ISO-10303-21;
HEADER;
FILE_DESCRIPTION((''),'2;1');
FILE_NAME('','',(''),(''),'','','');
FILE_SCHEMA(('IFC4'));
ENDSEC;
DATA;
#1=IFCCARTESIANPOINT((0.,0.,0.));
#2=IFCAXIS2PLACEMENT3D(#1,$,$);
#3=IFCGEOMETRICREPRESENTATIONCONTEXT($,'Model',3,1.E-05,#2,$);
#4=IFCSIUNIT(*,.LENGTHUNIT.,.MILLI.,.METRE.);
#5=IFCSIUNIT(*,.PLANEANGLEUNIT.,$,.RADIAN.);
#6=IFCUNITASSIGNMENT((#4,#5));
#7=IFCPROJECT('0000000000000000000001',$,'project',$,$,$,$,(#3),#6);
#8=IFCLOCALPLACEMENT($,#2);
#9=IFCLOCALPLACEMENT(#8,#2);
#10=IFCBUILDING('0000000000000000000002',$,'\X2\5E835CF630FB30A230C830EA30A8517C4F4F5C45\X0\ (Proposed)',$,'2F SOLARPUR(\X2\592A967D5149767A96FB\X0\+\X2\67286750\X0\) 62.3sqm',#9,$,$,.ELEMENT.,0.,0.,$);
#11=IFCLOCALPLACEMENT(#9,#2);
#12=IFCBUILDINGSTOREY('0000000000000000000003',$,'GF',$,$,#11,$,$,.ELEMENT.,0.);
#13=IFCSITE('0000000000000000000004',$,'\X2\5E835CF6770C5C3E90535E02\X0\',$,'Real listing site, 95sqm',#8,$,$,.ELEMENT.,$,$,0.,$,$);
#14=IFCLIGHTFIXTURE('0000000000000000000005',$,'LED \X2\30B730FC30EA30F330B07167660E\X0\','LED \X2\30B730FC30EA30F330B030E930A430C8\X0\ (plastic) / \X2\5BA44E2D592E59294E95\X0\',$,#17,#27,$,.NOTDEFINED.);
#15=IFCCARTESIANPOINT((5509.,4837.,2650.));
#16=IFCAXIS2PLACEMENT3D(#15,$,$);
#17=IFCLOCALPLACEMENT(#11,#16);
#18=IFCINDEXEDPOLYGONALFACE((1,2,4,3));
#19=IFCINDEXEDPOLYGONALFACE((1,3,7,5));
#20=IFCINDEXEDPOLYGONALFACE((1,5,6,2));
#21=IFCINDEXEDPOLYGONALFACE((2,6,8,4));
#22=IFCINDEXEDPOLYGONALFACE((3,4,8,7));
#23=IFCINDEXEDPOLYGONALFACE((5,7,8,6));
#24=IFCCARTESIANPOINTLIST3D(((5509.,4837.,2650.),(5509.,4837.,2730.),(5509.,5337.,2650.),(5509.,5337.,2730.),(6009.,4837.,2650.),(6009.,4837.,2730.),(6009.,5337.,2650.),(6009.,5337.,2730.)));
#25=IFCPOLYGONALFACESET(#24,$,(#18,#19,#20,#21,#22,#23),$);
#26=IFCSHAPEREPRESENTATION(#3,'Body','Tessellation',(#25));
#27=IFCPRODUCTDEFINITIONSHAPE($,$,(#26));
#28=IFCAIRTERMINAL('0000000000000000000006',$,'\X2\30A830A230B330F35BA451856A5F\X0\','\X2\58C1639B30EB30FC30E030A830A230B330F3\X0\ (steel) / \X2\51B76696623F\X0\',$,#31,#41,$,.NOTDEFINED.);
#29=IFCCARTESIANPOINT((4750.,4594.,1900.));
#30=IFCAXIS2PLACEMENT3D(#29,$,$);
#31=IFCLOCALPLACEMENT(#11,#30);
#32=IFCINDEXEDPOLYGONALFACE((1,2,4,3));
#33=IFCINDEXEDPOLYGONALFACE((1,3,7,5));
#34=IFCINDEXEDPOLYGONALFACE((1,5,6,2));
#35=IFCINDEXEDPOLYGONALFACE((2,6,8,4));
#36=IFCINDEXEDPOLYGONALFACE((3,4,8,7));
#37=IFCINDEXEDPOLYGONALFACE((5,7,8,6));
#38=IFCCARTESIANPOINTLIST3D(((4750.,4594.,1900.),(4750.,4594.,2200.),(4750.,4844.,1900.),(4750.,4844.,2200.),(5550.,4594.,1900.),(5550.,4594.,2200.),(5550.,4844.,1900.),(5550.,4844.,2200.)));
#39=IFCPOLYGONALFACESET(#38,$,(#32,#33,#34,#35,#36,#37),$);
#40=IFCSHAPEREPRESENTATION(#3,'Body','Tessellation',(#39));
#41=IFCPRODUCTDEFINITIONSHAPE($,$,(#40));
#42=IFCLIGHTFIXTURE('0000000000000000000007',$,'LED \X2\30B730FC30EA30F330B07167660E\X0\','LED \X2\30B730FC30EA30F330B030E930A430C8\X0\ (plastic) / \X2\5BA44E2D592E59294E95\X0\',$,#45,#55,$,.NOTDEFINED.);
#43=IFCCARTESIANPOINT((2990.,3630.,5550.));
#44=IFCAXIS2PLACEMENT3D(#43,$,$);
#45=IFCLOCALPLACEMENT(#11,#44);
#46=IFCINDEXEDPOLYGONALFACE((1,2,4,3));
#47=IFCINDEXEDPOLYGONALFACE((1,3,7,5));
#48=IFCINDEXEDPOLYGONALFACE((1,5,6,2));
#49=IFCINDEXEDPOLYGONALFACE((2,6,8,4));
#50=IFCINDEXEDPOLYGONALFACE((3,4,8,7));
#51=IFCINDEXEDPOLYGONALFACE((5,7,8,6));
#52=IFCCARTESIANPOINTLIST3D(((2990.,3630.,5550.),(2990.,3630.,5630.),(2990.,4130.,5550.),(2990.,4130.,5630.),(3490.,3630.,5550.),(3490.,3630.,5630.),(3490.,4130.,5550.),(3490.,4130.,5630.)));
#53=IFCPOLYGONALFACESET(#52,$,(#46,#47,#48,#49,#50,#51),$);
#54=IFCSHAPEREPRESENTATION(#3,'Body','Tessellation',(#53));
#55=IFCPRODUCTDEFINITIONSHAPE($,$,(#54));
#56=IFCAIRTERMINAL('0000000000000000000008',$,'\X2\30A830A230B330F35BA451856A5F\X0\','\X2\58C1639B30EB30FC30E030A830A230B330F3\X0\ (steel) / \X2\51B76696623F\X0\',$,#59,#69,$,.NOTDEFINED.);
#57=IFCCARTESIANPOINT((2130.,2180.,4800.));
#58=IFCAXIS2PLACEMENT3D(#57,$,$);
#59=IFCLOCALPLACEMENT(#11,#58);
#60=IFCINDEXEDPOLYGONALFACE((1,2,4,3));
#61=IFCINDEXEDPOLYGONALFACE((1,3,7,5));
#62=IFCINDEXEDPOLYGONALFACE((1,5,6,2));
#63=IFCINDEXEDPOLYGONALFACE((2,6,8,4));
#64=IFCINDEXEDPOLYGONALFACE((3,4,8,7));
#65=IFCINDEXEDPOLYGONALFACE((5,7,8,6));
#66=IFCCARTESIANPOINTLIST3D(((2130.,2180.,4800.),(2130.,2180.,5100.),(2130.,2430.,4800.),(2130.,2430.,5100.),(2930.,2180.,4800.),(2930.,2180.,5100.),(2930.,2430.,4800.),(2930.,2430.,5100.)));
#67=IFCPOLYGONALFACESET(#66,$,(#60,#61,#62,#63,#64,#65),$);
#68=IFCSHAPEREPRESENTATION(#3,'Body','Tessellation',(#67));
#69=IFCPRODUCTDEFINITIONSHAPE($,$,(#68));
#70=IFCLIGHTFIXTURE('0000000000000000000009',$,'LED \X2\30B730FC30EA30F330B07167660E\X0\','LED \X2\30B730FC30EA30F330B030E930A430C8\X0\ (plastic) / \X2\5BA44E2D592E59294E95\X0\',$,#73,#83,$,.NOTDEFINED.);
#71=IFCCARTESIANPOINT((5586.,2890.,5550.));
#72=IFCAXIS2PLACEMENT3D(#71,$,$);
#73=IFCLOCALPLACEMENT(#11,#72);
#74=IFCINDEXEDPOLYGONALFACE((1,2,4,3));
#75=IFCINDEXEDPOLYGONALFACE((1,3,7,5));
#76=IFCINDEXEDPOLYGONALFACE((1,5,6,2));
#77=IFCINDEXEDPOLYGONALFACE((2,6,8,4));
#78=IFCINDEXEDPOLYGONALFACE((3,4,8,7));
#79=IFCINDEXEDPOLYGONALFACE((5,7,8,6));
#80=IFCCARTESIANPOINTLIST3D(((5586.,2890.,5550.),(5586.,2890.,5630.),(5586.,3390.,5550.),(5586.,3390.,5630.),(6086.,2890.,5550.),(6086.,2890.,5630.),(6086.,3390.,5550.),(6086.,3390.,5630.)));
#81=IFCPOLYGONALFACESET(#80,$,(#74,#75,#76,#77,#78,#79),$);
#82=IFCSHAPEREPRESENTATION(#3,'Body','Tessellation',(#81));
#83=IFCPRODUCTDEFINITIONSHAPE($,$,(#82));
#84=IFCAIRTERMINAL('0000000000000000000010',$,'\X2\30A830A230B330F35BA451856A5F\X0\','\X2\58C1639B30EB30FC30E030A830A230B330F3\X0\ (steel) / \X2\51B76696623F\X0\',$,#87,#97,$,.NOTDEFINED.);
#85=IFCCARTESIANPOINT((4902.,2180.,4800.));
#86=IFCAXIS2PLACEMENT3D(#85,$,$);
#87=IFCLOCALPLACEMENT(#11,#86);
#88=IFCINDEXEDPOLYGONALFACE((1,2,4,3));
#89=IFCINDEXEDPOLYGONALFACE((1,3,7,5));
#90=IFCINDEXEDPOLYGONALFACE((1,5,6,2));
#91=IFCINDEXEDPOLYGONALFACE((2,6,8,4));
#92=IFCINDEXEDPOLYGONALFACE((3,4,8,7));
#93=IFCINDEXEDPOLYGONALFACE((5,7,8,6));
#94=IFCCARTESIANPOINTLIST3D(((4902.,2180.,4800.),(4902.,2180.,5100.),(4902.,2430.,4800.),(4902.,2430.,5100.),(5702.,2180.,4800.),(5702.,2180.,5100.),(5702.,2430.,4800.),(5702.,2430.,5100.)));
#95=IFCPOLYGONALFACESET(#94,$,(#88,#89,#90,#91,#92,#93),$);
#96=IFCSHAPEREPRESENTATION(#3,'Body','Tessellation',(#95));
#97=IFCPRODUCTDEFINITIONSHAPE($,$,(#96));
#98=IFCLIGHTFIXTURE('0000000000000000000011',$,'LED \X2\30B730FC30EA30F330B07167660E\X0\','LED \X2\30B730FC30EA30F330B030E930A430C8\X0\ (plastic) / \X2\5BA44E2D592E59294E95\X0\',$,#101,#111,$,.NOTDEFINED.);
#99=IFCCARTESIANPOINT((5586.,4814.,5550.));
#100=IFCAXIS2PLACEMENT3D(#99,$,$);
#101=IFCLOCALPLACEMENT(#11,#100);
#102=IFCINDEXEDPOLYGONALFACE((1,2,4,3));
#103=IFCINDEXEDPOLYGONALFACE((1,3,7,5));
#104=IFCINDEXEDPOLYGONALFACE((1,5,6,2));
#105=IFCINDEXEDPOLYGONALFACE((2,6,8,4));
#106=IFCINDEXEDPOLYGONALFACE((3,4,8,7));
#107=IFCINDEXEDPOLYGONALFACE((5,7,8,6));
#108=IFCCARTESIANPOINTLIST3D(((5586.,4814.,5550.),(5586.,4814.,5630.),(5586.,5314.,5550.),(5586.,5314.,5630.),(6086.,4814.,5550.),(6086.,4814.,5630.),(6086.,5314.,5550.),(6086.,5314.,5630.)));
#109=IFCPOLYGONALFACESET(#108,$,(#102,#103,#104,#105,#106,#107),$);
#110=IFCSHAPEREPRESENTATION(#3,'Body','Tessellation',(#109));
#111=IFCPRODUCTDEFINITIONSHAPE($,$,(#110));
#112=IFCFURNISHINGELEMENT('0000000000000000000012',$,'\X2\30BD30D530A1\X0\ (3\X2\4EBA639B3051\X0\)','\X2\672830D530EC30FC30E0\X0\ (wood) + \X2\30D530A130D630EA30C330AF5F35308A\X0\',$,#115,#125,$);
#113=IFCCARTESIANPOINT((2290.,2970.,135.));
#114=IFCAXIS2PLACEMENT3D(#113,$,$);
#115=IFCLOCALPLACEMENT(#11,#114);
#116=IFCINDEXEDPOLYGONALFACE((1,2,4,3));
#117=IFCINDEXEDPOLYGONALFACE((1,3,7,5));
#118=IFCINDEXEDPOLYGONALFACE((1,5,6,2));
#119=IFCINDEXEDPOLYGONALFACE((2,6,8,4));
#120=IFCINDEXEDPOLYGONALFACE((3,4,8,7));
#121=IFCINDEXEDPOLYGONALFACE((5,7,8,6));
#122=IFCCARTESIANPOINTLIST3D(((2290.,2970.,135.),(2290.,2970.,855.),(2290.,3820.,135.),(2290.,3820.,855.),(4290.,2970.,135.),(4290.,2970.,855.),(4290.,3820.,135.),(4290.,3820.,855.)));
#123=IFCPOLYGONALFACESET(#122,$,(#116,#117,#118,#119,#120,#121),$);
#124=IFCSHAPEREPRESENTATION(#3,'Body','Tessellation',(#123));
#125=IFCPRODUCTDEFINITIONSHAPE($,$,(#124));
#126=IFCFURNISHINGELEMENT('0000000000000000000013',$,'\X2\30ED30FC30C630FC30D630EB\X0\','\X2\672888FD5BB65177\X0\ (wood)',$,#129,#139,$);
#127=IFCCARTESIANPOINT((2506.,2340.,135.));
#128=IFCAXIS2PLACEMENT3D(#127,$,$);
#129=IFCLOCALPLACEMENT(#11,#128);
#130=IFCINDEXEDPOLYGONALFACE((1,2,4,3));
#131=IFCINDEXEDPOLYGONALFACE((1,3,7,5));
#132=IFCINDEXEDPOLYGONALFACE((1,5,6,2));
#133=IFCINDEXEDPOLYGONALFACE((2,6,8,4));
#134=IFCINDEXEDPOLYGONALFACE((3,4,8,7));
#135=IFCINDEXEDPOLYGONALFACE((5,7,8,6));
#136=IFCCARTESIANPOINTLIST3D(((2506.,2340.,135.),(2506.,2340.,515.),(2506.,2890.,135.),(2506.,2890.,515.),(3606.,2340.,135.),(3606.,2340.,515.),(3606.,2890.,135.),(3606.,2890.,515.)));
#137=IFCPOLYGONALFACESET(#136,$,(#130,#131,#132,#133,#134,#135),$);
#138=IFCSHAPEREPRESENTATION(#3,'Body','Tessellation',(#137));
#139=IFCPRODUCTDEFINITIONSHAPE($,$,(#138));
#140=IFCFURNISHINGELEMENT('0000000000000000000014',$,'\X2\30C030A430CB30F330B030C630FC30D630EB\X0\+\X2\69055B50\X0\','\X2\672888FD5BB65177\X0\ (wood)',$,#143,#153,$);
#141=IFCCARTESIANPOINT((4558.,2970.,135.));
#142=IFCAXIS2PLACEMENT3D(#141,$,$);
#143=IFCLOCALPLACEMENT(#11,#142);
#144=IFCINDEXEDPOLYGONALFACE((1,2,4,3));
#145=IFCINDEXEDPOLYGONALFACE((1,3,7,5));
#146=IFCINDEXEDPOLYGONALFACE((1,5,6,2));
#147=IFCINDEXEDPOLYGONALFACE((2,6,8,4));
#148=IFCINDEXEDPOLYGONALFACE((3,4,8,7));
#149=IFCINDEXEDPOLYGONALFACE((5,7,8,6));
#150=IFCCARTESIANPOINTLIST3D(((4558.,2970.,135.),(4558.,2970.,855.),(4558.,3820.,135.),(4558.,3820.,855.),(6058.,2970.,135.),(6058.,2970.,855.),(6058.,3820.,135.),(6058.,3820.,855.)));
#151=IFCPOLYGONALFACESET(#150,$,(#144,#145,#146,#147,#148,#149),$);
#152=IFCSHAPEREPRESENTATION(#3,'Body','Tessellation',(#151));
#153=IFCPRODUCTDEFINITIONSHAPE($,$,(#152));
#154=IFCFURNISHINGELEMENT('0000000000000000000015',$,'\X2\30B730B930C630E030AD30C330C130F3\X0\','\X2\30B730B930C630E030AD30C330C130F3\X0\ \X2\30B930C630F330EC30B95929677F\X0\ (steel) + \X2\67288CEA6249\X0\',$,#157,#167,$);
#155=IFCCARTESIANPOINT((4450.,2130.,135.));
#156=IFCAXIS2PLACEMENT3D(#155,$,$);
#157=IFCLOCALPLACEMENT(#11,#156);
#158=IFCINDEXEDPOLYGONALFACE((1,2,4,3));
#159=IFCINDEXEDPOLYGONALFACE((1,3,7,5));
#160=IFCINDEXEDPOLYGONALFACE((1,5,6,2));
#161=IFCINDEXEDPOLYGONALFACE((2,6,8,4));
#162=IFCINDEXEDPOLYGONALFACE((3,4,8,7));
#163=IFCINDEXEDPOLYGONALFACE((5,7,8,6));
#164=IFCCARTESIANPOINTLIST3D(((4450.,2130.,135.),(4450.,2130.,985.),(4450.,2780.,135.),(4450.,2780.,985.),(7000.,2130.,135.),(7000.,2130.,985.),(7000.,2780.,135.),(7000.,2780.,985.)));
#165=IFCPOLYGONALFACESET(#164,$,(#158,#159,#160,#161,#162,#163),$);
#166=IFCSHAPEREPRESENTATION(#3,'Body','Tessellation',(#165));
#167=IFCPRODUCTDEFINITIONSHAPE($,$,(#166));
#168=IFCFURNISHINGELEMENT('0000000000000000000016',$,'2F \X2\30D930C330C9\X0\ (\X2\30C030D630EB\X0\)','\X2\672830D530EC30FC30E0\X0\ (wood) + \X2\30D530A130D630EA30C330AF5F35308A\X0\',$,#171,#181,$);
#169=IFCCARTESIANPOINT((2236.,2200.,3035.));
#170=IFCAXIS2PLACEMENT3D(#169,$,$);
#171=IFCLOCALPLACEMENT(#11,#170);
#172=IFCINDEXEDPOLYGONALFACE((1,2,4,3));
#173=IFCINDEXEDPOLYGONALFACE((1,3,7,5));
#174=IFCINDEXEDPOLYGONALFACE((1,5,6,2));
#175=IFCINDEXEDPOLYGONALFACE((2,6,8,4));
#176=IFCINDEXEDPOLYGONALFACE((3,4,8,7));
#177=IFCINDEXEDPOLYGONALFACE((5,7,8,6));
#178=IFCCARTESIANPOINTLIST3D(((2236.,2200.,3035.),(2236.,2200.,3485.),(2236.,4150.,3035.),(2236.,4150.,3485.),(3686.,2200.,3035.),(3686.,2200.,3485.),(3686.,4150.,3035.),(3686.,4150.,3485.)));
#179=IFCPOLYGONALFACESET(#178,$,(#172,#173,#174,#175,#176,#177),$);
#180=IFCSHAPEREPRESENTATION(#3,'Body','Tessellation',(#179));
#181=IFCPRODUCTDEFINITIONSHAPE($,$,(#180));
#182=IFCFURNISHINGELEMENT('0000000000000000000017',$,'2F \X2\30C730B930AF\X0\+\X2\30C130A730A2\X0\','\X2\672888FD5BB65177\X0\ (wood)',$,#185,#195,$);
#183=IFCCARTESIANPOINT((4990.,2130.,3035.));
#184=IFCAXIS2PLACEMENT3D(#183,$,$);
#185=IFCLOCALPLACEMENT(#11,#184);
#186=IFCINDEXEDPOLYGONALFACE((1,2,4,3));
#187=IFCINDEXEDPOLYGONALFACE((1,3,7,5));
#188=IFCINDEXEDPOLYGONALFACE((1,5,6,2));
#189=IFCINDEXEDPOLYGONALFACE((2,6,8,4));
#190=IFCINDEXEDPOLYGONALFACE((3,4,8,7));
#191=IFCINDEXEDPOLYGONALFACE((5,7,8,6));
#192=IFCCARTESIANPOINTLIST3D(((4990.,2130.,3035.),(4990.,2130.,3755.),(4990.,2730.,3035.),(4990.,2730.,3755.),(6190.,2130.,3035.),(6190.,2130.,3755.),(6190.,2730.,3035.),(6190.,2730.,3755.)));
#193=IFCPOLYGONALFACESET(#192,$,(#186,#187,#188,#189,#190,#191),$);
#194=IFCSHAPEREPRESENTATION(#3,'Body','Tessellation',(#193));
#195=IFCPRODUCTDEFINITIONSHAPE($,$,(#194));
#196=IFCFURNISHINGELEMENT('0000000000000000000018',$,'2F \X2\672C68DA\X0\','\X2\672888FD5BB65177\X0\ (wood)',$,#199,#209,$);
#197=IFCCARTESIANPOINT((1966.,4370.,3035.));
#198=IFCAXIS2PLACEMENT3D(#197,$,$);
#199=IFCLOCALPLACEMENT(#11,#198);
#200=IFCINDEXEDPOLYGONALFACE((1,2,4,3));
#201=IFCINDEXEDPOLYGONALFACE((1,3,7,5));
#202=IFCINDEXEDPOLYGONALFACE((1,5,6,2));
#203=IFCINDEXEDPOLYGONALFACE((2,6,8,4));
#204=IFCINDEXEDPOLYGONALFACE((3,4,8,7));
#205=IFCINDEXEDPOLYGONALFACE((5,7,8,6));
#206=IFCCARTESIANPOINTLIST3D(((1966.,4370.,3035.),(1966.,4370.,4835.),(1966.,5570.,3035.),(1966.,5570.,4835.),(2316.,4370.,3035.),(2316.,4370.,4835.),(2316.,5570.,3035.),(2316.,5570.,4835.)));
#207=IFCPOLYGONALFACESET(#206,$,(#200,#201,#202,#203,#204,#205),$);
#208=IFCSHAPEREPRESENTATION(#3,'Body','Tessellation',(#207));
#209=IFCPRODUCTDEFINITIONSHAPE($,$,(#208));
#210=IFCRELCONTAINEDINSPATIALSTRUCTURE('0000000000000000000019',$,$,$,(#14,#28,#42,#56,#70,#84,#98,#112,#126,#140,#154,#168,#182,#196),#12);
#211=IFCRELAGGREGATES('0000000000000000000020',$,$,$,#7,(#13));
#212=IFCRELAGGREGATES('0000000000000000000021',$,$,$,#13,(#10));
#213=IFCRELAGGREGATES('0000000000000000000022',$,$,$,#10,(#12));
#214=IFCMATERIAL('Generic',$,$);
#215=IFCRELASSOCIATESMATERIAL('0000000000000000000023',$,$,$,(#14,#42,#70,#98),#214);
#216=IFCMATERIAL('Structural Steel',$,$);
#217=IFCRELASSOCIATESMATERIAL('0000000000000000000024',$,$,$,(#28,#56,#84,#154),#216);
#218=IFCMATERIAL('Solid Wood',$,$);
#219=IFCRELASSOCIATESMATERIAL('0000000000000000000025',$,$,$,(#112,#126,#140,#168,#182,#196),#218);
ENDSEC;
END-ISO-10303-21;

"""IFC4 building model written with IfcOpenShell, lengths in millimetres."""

from ifc_helpers import new_model, si_unit, frame, frame_2d, origin, place, context, project, spatial, rectangle, extrude, material, element, save


model = new_model("IFC4")

# Units and contexts
model_context = context("Model", 3, precision=1e-05, world=origin())
ifc_project = project(units=[si_unit("LENGTHUNIT", "METRE", prefix="MILLI"), si_unit("PLANEANGLEUNIT", "RADIAN")], contexts=[model_context])

# Site, building, storey
site_placement = place(None, origin())
site = spatial("IfcSite", under=ifc_project, at=site_placement, Name="広島県尾道市", ObjectType="Real listing site, 95sqm", CompositionType="ELEMENT", RefElevation=0.0)
building_placement = place(site_placement, origin())
building = spatial("IfcBuilding", under=site, at=building_placement, Name="広島・アトリエ兼住居 (Proposed)", ObjectType="2F SOLARPUR(太陽光発電+木材) 62.3sqm", CompositionType="ELEMENT", ElevationOfRefHeight=0.0, ElevationOfTerrain=0.0)
storey_placement = place(building_placement, origin())
storey = spatial("IfcBuildingStorey", under=building, at=storey_placement, Name="GF", CompositionType="ELEMENT", Elevation=0.0)

# Shared definitions
ifc_material_1 = material(Name="Solid Wood")

# Shared definitions
ifc_material_2 = material(Name="Structural Steel")

# Shared definitions
ifc_material_3 = material(Name="Generic")

# Light fixture
light_fixture_1_placement = place(storey_placement, frame((5509.0, 4837.0, 2650.0)))
element("IfcLightFixture", 1, at=light_fixture_1_placement, inside=storey, material=ifc_material_3, Name="LED シーリング照明", Description="LED シーリングライト (plastic) / 室中央天井", PredefinedType="NOTDEFINED", context=model_context, shape_type="SweptSolid", body=[
    extrude(rectangle(XDim=500.0, YDim=500.0, at=frame_2d((250.0, 250.0))), frame((5509.0, 4837.0, 2650.0)), (0.0, 0.0, 1.0), 80.0),
])

# Air terminal
air_terminal_1_placement = place(storey_placement, frame((4750.0, 4594.0, 1900.0)))
element("IfcAirTerminal", 2, at=air_terminal_1_placement, inside=storey, material=ifc_material_2, Name="エアコン室内機", Description="壁掛ルームエアコン (steel) / 冷暖房", PredefinedType="NOTDEFINED", context=model_context, shape_type="SweptSolid", body=[
    extrude(rectangle(XDim=800.0, YDim=250.0, at=frame_2d((400.0, 125.0))), frame((4750.0, 4594.0, 1900.0)), (0.0, 0.0, 1.0), 300.0),
])

# Light fixture
light_fixture_2_placement = place(storey_placement, frame((2990.0, 3630.0, 5550.0)))
element("IfcLightFixture", 3, at=light_fixture_2_placement, inside=storey, material=ifc_material_3, Name="LED シーリング照明", Description="LED シーリングライト (plastic) / 室中央天井", PredefinedType="NOTDEFINED", context=model_context, shape_type="SweptSolid", body=[
    extrude(rectangle(XDim=500.0, YDim=500.0, at=frame_2d((250.0, 250.0))), frame((2990.0, 3630.0, 5550.0)), (0.0, 0.0, 1.0), 80.0),
])

# Air terminal
air_terminal_2_placement = place(storey_placement, frame((2130.0, 2180.0, 4800.0)))
element("IfcAirTerminal", 4, at=air_terminal_2_placement, inside=storey, material=ifc_material_2, Name="エアコン室内機", Description="壁掛ルームエアコン (steel) / 冷暖房", PredefinedType="NOTDEFINED", context=model_context, shape_type="SweptSolid", body=[
    extrude(rectangle(XDim=800.0, YDim=250.0, at=frame_2d((400.0, 125.0))), frame((2130.0, 2180.0, 4800.0)), (0.0, 0.0, 1.0), 300.0),
])

# Light fixture
light_fixture_3_placement = place(storey_placement, frame((5586.0, 2890.0, 5550.0)))
element("IfcLightFixture", 5, at=light_fixture_3_placement, inside=storey, material=ifc_material_3, Name="LED シーリング照明", Description="LED シーリングライト (plastic) / 室中央天井", PredefinedType="NOTDEFINED", context=model_context, shape_type="SweptSolid", body=[
    extrude(rectangle(XDim=500.0, YDim=500.0, at=frame_2d((250.0, 250.0))), frame((5586.0, 2890.0, 5550.0)), (0.0, 0.0, 1.0), 80.0),
])

# Air terminal
air_terminal_3_placement = place(storey_placement, frame((4902.0, 2180.0, 4800.0)))
element("IfcAirTerminal", 6, at=air_terminal_3_placement, inside=storey, material=ifc_material_2, Name="エアコン室内機", Description="壁掛ルームエアコン (steel) / 冷暖房", PredefinedType="NOTDEFINED", context=model_context, shape_type="SweptSolid", body=[
    extrude(rectangle(XDim=800.0, YDim=250.0, at=frame_2d((400.0, 125.0))), frame((4902.0, 2180.0, 4800.0)), (0.0, 0.0, 1.0), 300.0),
])

# Light fixture
light_fixture_4_placement = place(storey_placement, frame((5586.0, 4814.0, 5550.0)))
element("IfcLightFixture", 7, at=light_fixture_4_placement, inside=storey, material=ifc_material_3, Name="LED シーリング照明", Description="LED シーリングライト (plastic) / 室中央天井", PredefinedType="NOTDEFINED", context=model_context, shape_type="SweptSolid", body=[
    extrude(rectangle(XDim=500.0, YDim=500.0, at=frame_2d((250.0, 250.0))), frame((5586.0, 4814.0, 5550.0)), (0.0, 0.0, 1.0), 80.0),
])

# Furnishing elements
furnishing_1_placement = place(storey_placement, frame((2290.0, 2970.0, 135.0)))
element("IfcFurnishingElement", 8, at=furnishing_1_placement, inside=storey, material=ifc_material_1, Name="ソファ (3人掛け)", Description="木フレーム (wood) + ファブリック張り", context=model_context, shape_type="SweptSolid", body=[
    extrude(rectangle(XDim=2000.0, YDim=850.0, at=frame_2d((1000.0, 425.0))), frame((2290.0, 2970.0, 135.0)), (0.0, 0.0, 1.0), 720.0),
])
furnishing_2_placement = place(storey_placement, frame((2506.0, 2340.0, 135.0)))
element("IfcFurnishingElement", 9, at=furnishing_2_placement, inside=storey, material=ifc_material_1, Name="ローテーブル", Description="木製家具 (wood)", context=model_context, shape_type="SweptSolid", body=[
    extrude(rectangle(XDim=1100.0, YDim=550.0, at=frame_2d((550.0, 275.0))), frame((2506.0, 2340.0, 135.0)), (0.0, 0.0, 1.0), 380.0),
])
furnishing_3_placement = place(storey_placement, frame((4558.0, 2970.0, 135.0)))
element("IfcFurnishingElement", 10, at=furnishing_3_placement, inside=storey, material=ifc_material_1, Name="ダイニングテーブル+椅子", Description="木製家具 (wood)", context=model_context, shape_type="SweptSolid", body=[
    extrude(rectangle(XDim=1500.0, YDim=850.0, at=frame_2d((750.0, 425.0))), frame((4558.0, 2970.0, 135.0)), (0.0, 0.0, 1.0), 720.0),
])
furnishing_4_placement = place(storey_placement, frame((4450.0, 2130.0, 135.0)))
element("IfcFurnishingElement", 11, at=furnishing_4_placement, inside=storey, material=ifc_material_2, Name="システムキッチン", Description="システムキッチン ステンレス天板 (steel) + 木質扉", context=model_context, shape_type="SweptSolid", body=[
    extrude(rectangle(XDim=2550.0, YDim=650.0, at=frame_2d((1275.0, 325.0))), frame((4450.0, 2130.0, 135.0)), (0.0, 0.0, 1.0), 850.0),
])
furnishing_5_placement = place(storey_placement, frame((2236.0, 2200.0, 3035.0)))
element("IfcFurnishingElement", 12, at=furnishing_5_placement, inside=storey, material=ifc_material_1, Name="2F ベッド (ダブル)", Description="木フレーム (wood) + ファブリック張り", context=model_context, shape_type="SweptSolid", body=[
    extrude(rectangle(XDim=1450.0, YDim=1950.0, at=frame_2d((725.0, 975.0))), frame((2236.0, 2200.0, 3035.0)), (0.0, 0.0, 1.0), 450.0),
])
furnishing_6_placement = place(storey_placement, frame((4990.0, 2130.0, 3035.0)))
element("IfcFurnishingElement", 13, at=furnishing_6_placement, inside=storey, material=ifc_material_1, Name="2F デスク+チェア", Description="木製家具 (wood)", context=model_context, shape_type="SweptSolid", body=[
    extrude(rectangle(XDim=1200.0, YDim=600.0, at=frame_2d((600.0, 300.0))), frame((4990.0, 2130.0, 3035.0)), (0.0, 0.0, 1.0), 720.0),
])
furnishing_7_placement = place(storey_placement, frame((1966.0, 4370.0, 3035.0)))
element("IfcFurnishingElement", 14, at=furnishing_7_placement, inside=storey, material=ifc_material_1, Name="2F 本棚", Description="木製家具 (wood)", context=model_context, shape_type="SweptSolid", body=[
    extrude(rectangle(XDim=350.0, YDim=1200.0, at=frame_2d((175.0, 600.0))), frame((1966.0, 4370.0, 3035.0)), (0.0, 0.0, 1.0), 1800.0),
])

save(model, "model.ifc")
